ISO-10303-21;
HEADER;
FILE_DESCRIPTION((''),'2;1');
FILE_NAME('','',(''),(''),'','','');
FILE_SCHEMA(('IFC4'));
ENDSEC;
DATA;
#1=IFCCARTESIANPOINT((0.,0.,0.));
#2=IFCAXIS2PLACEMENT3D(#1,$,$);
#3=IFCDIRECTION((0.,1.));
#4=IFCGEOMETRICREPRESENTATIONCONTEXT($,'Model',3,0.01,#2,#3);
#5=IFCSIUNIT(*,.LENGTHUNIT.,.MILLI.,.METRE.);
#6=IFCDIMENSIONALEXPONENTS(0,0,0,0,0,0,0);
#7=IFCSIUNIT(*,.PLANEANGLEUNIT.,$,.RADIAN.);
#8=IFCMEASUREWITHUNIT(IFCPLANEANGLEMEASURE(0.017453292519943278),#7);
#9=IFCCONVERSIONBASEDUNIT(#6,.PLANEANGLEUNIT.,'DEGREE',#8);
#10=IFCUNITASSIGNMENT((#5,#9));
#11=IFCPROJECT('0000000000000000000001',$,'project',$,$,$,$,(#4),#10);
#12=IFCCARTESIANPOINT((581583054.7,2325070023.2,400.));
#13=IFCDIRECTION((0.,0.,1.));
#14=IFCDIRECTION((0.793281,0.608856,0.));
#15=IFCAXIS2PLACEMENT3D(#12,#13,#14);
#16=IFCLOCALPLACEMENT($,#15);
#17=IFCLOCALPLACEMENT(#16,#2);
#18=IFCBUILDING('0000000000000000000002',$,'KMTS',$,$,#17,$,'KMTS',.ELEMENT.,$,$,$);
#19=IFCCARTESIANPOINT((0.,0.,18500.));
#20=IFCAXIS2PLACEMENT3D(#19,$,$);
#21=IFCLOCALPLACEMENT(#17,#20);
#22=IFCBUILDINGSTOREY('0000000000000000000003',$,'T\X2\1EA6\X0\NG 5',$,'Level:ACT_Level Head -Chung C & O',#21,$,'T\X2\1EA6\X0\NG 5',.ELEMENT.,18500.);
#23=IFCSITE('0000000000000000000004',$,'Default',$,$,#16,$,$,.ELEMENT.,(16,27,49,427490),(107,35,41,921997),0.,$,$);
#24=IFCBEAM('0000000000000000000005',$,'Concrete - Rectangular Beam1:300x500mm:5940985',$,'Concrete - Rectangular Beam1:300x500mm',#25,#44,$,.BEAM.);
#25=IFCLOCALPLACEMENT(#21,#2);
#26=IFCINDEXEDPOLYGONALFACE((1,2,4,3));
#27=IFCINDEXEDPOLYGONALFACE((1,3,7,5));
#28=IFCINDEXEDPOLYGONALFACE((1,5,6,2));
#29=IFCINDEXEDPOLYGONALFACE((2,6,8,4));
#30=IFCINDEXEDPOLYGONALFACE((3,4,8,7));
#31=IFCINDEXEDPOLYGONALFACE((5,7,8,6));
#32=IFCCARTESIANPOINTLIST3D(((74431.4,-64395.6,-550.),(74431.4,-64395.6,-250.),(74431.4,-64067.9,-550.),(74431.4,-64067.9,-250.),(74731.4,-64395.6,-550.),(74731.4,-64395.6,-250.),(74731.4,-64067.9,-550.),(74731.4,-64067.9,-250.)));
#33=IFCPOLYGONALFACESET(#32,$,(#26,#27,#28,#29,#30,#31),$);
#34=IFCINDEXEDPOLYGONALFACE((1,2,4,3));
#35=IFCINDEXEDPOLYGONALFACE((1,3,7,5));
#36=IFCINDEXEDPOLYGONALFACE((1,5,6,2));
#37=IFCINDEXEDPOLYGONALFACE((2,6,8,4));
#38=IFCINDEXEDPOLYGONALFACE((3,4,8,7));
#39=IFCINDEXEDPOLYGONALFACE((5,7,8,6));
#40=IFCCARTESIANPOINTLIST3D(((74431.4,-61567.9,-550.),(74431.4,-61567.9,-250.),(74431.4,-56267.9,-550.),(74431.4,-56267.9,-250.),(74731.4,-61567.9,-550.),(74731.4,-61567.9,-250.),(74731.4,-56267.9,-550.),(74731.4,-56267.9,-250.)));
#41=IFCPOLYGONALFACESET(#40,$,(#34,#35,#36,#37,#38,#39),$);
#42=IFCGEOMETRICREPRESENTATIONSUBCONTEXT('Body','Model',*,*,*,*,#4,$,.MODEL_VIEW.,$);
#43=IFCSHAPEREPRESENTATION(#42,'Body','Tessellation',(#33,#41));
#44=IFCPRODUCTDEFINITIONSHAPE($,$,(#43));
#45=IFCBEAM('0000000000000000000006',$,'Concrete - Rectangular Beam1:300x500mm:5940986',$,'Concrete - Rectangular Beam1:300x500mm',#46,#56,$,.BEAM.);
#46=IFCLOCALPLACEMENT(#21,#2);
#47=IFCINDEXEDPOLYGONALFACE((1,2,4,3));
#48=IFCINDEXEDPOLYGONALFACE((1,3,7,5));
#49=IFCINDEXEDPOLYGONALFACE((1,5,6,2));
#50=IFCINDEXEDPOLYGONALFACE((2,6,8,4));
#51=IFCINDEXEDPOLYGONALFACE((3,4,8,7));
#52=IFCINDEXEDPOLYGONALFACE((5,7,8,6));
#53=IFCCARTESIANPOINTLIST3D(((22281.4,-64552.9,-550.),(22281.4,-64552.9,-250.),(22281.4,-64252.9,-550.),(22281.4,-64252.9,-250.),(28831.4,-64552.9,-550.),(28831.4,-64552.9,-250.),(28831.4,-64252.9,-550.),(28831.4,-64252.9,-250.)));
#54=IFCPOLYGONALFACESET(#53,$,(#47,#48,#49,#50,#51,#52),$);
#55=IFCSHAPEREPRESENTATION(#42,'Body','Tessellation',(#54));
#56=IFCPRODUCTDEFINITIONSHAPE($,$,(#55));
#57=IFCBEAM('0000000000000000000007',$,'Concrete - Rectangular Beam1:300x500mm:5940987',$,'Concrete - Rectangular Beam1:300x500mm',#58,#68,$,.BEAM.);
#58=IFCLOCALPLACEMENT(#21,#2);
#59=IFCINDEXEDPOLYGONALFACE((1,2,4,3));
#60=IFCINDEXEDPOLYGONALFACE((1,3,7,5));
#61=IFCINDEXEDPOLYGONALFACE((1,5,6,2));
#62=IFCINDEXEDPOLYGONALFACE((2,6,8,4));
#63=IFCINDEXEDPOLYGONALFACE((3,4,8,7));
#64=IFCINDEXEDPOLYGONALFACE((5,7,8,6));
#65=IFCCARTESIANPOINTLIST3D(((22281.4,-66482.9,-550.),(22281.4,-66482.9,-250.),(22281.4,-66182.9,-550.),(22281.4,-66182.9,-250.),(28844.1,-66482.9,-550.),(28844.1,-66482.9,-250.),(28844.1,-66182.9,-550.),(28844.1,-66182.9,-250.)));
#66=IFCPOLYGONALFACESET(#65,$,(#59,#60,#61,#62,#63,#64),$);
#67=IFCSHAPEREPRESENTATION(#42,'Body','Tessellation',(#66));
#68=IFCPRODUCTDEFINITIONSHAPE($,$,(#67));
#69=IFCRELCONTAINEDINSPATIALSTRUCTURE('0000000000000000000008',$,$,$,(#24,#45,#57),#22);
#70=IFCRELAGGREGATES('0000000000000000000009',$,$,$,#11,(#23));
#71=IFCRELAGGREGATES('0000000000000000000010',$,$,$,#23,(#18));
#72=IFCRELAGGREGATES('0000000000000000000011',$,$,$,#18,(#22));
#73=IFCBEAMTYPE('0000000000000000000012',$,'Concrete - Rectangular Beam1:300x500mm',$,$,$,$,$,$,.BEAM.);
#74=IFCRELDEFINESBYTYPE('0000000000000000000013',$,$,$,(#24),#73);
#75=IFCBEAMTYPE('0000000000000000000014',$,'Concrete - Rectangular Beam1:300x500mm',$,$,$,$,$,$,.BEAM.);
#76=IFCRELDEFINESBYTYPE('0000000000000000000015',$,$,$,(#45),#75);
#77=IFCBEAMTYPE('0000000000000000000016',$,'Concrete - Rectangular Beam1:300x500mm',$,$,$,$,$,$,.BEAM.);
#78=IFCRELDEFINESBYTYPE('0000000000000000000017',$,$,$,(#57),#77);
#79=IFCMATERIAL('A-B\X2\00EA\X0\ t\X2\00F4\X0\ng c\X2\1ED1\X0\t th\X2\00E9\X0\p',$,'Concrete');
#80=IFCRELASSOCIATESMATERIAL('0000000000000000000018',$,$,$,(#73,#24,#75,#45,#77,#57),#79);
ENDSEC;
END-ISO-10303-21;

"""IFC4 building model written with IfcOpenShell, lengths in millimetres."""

from ifc_helpers import new_model, entity, si_unit, converted_unit, direction, frame, origin, place, context, subcontext, project, spatial, indexed_curve, outline, extrude, source, transform, mapped, material, type_object, type_shapes, element, save


model = new_model("IFC4")

# Units and contexts
model_context = context("Model", 3, precision=0.01, world=origin(), true_north=direction((0.0, 1.0)))
body_context = subcontext(model_context, "Body", "Model", "MODEL_VIEW")
ifc_project = project(units=[si_unit("LENGTHUNIT", "METRE", prefix="MILLI"), converted_unit("PLANEANGLEUNIT", "DEGREE", entity("IfcPlaneAngleMeasure", 0.017453292519943278), si_unit("PLANEANGLEUNIT", "RADIAN"), dimensions=[0, 0, 0, 0, 0, 0, 0])], contexts=[model_context])

# Site, building, storey
site_placement = place(None, frame((581583054.7, 2325070023.2, 400.0), z_axis=(0.0, 0.0, 1.0), x_axis=(0.793281, 0.608856, 0.0)))
site = spatial("IfcSite", under=ifc_project, at=site_placement, Name="Default", CompositionType="ELEMENT", RefLatitude=(16, 27, 49, 427490), RefLongitude=(107, 35, 41, 921997), RefElevation=0.0)
building_placement = place(site_placement, origin())
building = spatial("IfcBuilding", under=site, at=building_placement, Name="KMTS", LongName="KMTS", CompositionType="ELEMENT")
storey_placement = place(building_placement, frame((0.0, 0.0, 18500.0)))
storey = spatial("IfcBuildingStorey", under=building, at=storey_placement, Name="TẦNG 5", ObjectType="Level:ACT_Level Head -Chung C & O", LongName="TẦNG 5", CompositionType="ELEMENT", Elevation=18500.0)

# Beams
ifc_material_1 = material(Name="A-Bê tông cốt thép", Category="Concrete")
beam_type_1 = type_object("IfcBeamType", Name="Concrete - Rectangular Beam1:300x500mm", PredefinedType="BEAM", material=ifc_material_1)
shared_shape_1 = source(origin(), body_context, "Body", "SweptSolid", [
    extrude(outline(indexed_curve([(-150.0, -150.0), (150.0, -150.0), (150.0, 150.0), (-150.0, 150.0), (-150.0, -150.0)], self_intersect=False)), frame((74581.4, -64067.9, 18100.0), z_axis=(0.0, -1.0, 0.0), x_axis=(-1.0, 0.0, 0.0)), (0.0, 0.0, 1.0), 327.7),
    extrude(outline(indexed_curve([(-150.0, -150.0), (150.0, -150.0), (150.0, 150.0), (-150.0, 150.0), (-150.0, -150.0)], self_intersect=False)), frame((74581.4, -56267.9, 18100.0), z_axis=(0.0, -1.0, 0.0), x_axis=(-1.0, 0.0, 0.0)), (0.0, 0.0, 1.0), 5300.0),
])
type_shapes(beam_type_1, [shared_shape_1])
beam_1_placement = place(storey_placement, frame((0.0, 0.0, -18500.0)))
element("IfcBeam", 1, at=beam_1_placement, inside=storey, type_object=beam_type_1, material=ifc_material_1, Name="Concrete - Rectangular Beam1:300x500mm:5940985", ObjectType="Concrete - Rectangular Beam1:300x500mm", PredefinedType="BEAM", context=body_context, shape_type="MappedRepresentation", body=[
    mapped(shared_shape_1, transform((0.0, 0.0, 0.0), scale=1.0)),
])
beam_type_2 = type_object("IfcBeamType", Name="Concrete - Rectangular Beam1:300x500mm", PredefinedType="BEAM", material=ifc_material_1)
shared_shape_2 = source(origin(), body_context, "Body", "SweptSolid", [
    extrude(outline(indexed_curve([(-150.0, -150.0), (150.0, -150.0), (150.0, 150.0), (-150.0, 150.0), (-150.0, -150.0)], self_intersect=False)), frame((28831.4, -64402.9, 18100.0), z_axis=(-1.0, 0.0, 0.0), x_axis=(0.0, 0.0, -1.0)), (0.0, 0.0, 1.0), 6550.0),
])
type_shapes(beam_type_2, [shared_shape_2])
beam_2_placement = place(storey_placement, frame((0.0, 0.0, -18500.0)))
element("IfcBeam", 2, at=beam_2_placement, inside=storey, type_object=beam_type_2, material=ifc_material_1, Name="Concrete - Rectangular Beam1:300x500mm:5940986", ObjectType="Concrete - Rectangular Beam1:300x500mm", PredefinedType="BEAM", context=body_context, shape_type="MappedRepresentation", body=[
    mapped(shared_shape_2, transform((0.0, 0.0, 0.0), scale=1.0)),
])
beam_type_3 = type_object("IfcBeamType", Name="Concrete - Rectangular Beam1:300x500mm", PredefinedType="BEAM", material=ifc_material_1)
shared_shape_3 = source(origin(), body_context, "Body", "SweptSolid", [
    extrude(outline(indexed_curve([(-150.0, -150.0), (150.0, -150.0), (150.0, 150.0), (-150.0, 150.0), (-150.0, -150.0)], self_intersect=False)), frame((22281.4, -66332.9, 18100.0), z_axis=(1.0, 0.0, 0.0), x_axis=(0.0, 0.0, -1.0)), (0.0, 0.0, 1.0), 6562.7),
])
type_shapes(beam_type_3, [shared_shape_3])
beam_3_placement = place(storey_placement, frame((0.0, 0.0, -18500.0)))
element("IfcBeam", 3, at=beam_3_placement, inside=storey, type_object=beam_type_3, material=ifc_material_1, Name="Concrete - Rectangular Beam1:300x500mm:5940987", ObjectType="Concrete - Rectangular Beam1:300x500mm", PredefinedType="BEAM", context=body_context, shape_type="MappedRepresentation", body=[
    mapped(shared_shape_3, transform((0.0, 0.0, 0.0), scale=1.0)),
])

save(model, "model.ifc")
